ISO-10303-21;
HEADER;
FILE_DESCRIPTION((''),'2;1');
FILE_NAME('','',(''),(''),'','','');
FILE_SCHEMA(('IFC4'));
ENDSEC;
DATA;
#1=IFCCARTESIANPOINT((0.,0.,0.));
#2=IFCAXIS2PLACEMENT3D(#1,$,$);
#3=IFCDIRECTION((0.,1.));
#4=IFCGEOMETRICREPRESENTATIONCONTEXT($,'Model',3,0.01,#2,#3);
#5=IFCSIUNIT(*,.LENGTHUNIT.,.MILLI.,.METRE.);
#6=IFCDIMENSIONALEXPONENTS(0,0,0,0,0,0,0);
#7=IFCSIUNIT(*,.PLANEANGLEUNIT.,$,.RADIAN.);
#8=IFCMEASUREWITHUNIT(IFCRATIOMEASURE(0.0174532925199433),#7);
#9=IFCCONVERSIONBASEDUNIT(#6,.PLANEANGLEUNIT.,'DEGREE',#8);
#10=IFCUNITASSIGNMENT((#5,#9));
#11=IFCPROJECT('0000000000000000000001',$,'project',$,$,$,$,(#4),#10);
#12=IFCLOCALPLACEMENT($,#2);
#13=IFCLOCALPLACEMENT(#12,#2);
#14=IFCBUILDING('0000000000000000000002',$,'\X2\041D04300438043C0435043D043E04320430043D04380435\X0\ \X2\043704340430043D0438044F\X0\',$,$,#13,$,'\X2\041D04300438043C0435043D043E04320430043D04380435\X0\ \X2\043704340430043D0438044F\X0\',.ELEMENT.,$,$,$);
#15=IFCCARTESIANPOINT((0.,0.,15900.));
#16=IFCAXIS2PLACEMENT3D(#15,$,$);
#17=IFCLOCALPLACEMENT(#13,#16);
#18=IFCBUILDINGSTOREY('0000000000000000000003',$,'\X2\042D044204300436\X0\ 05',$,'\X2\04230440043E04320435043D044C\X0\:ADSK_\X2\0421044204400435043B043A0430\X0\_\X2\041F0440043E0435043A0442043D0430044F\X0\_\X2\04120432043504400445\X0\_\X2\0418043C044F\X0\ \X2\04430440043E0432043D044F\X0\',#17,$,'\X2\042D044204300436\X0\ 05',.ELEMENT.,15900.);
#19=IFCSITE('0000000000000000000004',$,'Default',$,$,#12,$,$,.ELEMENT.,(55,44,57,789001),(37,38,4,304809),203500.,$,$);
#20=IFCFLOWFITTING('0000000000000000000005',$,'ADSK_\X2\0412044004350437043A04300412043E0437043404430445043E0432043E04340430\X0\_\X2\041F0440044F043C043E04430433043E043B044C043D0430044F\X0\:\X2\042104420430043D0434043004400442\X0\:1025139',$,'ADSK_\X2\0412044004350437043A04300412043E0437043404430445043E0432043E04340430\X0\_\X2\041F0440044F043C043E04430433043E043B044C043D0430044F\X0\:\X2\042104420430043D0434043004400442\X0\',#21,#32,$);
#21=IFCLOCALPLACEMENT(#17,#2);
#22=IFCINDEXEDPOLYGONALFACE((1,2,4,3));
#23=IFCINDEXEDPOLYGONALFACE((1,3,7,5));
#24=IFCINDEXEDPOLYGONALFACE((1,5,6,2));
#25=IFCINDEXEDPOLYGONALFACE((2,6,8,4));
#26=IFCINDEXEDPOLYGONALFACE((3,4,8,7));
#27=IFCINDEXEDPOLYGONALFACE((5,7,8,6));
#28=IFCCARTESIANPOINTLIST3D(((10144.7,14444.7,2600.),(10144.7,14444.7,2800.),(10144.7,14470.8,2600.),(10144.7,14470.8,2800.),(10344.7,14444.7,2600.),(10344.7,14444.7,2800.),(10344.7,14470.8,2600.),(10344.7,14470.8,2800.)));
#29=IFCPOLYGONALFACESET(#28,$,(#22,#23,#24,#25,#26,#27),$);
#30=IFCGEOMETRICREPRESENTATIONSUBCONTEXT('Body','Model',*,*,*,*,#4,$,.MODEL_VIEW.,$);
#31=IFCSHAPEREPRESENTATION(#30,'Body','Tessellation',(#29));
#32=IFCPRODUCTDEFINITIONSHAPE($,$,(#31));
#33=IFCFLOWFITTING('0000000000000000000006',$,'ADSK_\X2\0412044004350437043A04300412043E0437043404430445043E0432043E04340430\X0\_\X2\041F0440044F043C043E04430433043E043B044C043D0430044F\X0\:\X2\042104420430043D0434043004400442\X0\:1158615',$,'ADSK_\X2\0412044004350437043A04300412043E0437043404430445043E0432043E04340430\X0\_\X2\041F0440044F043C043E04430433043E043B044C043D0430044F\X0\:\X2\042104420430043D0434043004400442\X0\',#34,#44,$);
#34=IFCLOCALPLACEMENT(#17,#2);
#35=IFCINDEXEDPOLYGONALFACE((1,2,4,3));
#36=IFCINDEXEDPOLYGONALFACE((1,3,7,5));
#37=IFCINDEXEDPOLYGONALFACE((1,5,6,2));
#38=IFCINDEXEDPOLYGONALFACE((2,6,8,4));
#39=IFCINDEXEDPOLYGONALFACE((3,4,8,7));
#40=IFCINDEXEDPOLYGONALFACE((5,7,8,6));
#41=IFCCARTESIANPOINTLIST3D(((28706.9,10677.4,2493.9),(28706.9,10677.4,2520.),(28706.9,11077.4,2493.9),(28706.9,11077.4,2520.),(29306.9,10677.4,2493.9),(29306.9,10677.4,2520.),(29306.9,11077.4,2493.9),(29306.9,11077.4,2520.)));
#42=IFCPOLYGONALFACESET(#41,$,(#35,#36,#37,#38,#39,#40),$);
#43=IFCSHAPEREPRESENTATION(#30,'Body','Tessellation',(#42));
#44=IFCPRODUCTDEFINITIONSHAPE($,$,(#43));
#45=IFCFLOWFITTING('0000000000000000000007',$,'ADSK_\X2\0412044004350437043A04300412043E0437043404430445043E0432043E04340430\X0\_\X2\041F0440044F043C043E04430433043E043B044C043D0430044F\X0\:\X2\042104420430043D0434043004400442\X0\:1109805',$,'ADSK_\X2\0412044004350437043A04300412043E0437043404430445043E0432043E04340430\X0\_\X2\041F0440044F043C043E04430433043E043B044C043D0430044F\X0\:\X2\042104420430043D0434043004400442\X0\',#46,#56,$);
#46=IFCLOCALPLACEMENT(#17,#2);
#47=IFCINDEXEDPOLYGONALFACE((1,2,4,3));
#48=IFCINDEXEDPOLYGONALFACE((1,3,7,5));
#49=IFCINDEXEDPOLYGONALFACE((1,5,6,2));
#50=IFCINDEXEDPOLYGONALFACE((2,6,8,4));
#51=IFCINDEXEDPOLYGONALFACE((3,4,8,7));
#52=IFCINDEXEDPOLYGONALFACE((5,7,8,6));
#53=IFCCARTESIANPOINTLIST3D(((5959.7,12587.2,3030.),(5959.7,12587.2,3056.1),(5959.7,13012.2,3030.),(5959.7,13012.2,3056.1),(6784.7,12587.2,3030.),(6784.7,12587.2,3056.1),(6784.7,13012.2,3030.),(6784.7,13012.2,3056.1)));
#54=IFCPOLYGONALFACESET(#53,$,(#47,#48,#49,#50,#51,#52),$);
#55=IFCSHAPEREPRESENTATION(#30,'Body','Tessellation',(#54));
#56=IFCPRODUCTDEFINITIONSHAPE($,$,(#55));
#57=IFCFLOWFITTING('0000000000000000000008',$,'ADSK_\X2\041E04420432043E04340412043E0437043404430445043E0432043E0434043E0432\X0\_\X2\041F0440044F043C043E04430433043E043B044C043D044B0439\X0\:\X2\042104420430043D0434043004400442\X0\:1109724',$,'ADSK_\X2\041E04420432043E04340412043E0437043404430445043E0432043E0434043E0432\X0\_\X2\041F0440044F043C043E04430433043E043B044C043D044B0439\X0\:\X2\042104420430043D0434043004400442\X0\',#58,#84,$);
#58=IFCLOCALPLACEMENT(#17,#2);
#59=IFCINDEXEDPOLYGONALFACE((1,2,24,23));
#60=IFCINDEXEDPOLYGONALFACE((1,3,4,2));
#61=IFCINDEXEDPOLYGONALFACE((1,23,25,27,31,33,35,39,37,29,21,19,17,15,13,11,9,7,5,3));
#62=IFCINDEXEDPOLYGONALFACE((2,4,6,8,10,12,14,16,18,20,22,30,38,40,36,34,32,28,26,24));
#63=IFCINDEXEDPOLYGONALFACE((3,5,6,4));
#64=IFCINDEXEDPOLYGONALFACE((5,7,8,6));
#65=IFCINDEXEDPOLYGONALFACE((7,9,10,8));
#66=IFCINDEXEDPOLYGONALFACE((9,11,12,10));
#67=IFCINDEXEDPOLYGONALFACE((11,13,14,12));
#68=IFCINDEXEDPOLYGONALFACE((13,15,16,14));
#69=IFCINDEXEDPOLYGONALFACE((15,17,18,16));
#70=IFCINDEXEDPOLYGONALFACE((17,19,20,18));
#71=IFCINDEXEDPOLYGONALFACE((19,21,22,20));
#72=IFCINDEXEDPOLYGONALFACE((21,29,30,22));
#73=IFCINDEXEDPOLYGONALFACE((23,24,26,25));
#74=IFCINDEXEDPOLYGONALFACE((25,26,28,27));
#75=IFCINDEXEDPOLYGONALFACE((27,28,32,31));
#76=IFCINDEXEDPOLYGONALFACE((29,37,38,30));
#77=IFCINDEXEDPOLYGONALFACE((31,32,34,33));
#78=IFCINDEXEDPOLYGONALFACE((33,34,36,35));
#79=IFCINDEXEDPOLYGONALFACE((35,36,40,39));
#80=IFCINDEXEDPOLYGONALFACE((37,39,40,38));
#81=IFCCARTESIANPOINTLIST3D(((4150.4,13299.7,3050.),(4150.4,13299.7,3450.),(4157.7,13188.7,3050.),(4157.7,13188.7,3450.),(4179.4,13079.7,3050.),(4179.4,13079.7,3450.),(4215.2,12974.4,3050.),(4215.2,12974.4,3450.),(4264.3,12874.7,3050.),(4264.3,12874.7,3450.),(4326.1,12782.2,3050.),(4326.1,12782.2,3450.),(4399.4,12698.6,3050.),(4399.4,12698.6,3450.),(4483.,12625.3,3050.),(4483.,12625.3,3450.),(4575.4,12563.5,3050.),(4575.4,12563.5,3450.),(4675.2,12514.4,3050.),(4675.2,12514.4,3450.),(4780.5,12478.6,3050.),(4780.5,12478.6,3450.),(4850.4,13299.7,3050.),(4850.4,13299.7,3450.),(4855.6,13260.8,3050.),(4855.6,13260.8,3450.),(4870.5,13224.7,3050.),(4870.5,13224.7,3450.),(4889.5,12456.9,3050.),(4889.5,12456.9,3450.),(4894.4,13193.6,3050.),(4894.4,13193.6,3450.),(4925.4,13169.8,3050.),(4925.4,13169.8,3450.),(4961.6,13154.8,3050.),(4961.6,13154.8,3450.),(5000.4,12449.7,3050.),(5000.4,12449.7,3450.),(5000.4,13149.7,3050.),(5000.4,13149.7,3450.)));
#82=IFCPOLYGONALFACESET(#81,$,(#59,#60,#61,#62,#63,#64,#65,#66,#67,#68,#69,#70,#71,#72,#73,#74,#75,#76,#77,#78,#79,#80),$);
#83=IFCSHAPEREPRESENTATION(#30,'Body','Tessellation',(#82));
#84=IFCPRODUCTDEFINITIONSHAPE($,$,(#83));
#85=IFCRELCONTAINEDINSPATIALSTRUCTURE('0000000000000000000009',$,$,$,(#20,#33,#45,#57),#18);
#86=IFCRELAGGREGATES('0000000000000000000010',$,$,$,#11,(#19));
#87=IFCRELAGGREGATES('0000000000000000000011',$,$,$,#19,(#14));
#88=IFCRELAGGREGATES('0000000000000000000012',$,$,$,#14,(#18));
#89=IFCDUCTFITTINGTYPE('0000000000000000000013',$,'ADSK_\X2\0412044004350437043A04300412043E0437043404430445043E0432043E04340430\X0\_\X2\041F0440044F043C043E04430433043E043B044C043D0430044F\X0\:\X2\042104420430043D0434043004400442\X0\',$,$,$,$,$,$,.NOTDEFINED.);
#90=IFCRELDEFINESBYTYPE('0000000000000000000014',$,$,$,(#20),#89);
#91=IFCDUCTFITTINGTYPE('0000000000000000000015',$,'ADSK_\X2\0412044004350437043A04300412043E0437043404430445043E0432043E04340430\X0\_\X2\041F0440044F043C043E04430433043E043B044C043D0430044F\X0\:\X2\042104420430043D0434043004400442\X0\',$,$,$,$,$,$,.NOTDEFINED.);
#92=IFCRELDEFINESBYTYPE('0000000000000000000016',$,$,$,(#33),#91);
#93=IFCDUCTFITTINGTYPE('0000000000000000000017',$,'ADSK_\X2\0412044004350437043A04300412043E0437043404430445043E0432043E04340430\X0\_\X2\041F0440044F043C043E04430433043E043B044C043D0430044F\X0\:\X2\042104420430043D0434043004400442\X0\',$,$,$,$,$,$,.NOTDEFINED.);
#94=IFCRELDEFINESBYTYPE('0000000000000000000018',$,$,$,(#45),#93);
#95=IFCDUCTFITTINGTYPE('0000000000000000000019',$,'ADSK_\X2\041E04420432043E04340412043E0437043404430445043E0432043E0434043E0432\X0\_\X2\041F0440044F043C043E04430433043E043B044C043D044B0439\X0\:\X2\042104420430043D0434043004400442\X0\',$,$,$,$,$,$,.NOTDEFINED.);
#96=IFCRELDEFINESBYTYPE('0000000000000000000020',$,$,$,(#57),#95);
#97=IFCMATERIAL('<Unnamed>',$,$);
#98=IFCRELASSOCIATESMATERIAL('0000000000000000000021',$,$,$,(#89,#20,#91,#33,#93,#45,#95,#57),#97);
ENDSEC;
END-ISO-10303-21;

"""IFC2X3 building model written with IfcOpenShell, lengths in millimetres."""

from ifc_helpers import new_model, entity, si_unit, converted_unit, direction, frame, frame_2d, origin, origin_2d_with_axis, place, context, subcontext, project, spatial, polyline, circle_curve, parameter, trimmed, segment, composite_curve, rectangle, outline, extrude, source, transform, mapped, material, type_object, type_shapes, element, save


model = new_model("IFC2X3")

# Units and contexts
model_context = context("Model", 3, precision=0.01, world=origin(), true_north=direction((0.0, 1.0)))
body_context = subcontext(model_context, "Body", "Model", "MODEL_VIEW")
ifc_project = project(units=[si_unit("LENGTHUNIT", "METRE", prefix="MILLI"), converted_unit("PLANEANGLEUNIT", "DEGREE", entity("IfcRatioMeasure", 0.0174532925199433), si_unit("PLANEANGLEUNIT", "RADIAN"), dimensions=[0, 0, 0, 0, 0, 0, 0])], contexts=[model_context])

# Site, building, storey
site_placement = place(None, origin())
site = spatial("IfcSite", under=ifc_project, at=site_placement, Name="Default", CompositionType="ELEMENT", RefLatitude=(55, 44, 57, 789001), RefLongitude=(37, 38, 4, 304809), RefElevation=203500.0)
building_placement = place(site_placement, origin())
building = spatial("IfcBuilding", under=site, at=building_placement, Name="Наименование здания", LongName="Наименование здания", CompositionType="ELEMENT")
storey_placement = place(building_placement, frame((0.0, 0.0, 15900.0)))
storey = spatial("IfcBuildingStorey", under=building, at=storey_placement, Name="Этаж 05", ObjectType="Уровень:ADSK_Стрелка_Проектная_Вверх_Имя уровня", LongName="Этаж 05", CompositionType="ELEMENT", Elevation=15900.0)

# Shared definitions
ifc_material_1 = material(Name="<Unnamed>")

# Flow fittings
duct_fitting_type_1 = type_object("IfcDuctFittingType", Name="ADSK_ВрезкаВоздуховода_Прямоугольная:Стандарт", PredefinedType="NOTDEFINED", material=ifc_material_1)
shared_shape_1 = source(origin(), body_context, "Body", "SweptSolid", [
    extrude(rectangle(XDim=200.0, YDim=26.1, at=origin_2d_with_axis()), frame((7.0, 0.0, -100.0), z_axis=(0.0, 0.0, 1.0), x_axis=(0.0, -1.0, 0.0)), (0.0, 0.0, 1.0), 200.0),
])
type_shapes(duct_fitting_type_1, [shared_shape_1])
flow_fitting_1_placement = place(storey_placement, frame((10244.7, 14450.8, 2700.0), z_axis=(1.0, 0.0, 0.0), x_axis=(0.0, 1.0, 0.0)))
element("IfcFlowFitting", 1, at=flow_fitting_1_placement, inside=storey, type_object=duct_fitting_type_1, material=ifc_material_1, Name="ADSK_ВрезкаВоздуховода_Прямоугольная:Стандарт:1025139", ObjectType="ADSK_ВрезкаВоздуховода_Прямоугольная:Стандарт", context=body_context, shape_type="MappedRepresentation", body=[
    mapped(shared_shape_1, transform((0.0, 0.0, 0.0), scale=1.0)),
])
duct_fitting_type_2 = type_object("IfcDuctFittingType", Name="ADSK_ВрезкаВоздуховода_Прямоугольная:Стандарт", PredefinedType="NOTDEFINED", material=ifc_material_1)
shared_shape_2 = source(origin(), body_context, "Body", "SweptSolid", [
    extrude(rectangle(XDim=26.1, YDim=400.0, at=origin_2d_with_axis()), frame((7.0, 0.0, -300.0)), (0.0, 0.0, 1.0), 600.0),
])
type_shapes(duct_fitting_type_2, [shared_shape_2])
flow_fitting_2_placement = place(storey_placement, frame((29006.9, 10877.4, 2500.0), z_axis=(1.0, 0.0, 0.0), x_axis=(0.0, 0.0, 1.0)))
element("IfcFlowFitting", 2, at=flow_fitting_2_placement, inside=storey, type_object=duct_fitting_type_2, material=ifc_material_1, Name="ADSK_ВрезкаВоздуховода_Прямоугольная:Стандарт:1158615", ObjectType="ADSK_ВрезкаВоздуховода_Прямоугольная:Стандарт", context=body_context, shape_type="MappedRepresentation", body=[
    mapped(shared_shape_2, transform((0.0, 0.0, 0.0), scale=1.0)),
])
duct_fitting_type_3 = type_object("IfcDuctFittingType", Name="ADSK_ВрезкаВоздуховода_Прямоугольная:Стандарт", PredefinedType="NOTDEFINED", material=ifc_material_1)
shared_shape_3 = source(origin(), body_context, "Body", "SweptSolid", [
    extrude(rectangle(XDim=825.0, YDim=26.1, at=origin_2d_with_axis()), frame((7.0, 0.0, -212.5), z_axis=(0.0, 0.0, 1.0), x_axis=(0.0, -1.0, 0.0)), (0.0, 0.0, 1.0), 425.0),
])
type_shapes(duct_fitting_type_3, [shared_shape_3])
flow_fitting_3_placement = place(storey_placement, frame((6372.2, 12799.7, 3050.0), z_axis=(0.0, -1.0, 0.0), x_axis=(0.0, 0.0, -1.0)))
element("IfcFlowFitting", 3, at=flow_fitting_3_placement, inside=storey, type_object=duct_fitting_type_3, material=ifc_material_1, Name="ADSK_ВрезкаВоздуховода_Прямоугольная:Стандарт:1109805", ObjectType="ADSK_ВрезкаВоздуховода_Прямоугольная:Стандарт", context=body_context, shape_type="MappedRepresentation", body=[
    mapped(shared_shape_3, transform((0.0, 0.0, 0.0), scale=1.0)),
])
duct_fitting_type_4 = type_object("IfcDuctFittingType", Name="ADSK_ОтводВоздуховодов_Прямоугольный:Стандарт", PredefinedType="NOTDEFINED", material=ifc_material_1)
shared_shape_4 = source(origin(), body_context, "Body", "SweptSolid", [
    extrude(outline(composite_curve([segment(polyline([(-600.0, -250.0), (100.0, -250.0)]), True, "CONTINUOUS"), segment(trimmed(circle_curve(frame_2d((250.0, -250.0), x_axis=(0.0, 1.0)), 150.0), [parameter(0.0)], [parameter(90.0)], True, "PARAMETER"), False, "CONTINUOUS"), segment(polyline([(250.0, -100.0), (250.0, 600.0)]), True, "CONTINUOUS"), segment(trimmed(circle_curve(frame_2d((250.0, -250.0), x_axis=(0.0, 1.0)), 850.0), [parameter(0.0)], [parameter(90.0)], True, "PARAMETER"), True, "CONTINUOUS")], self_intersect=False)), frame((-250.0, 250.0, -200.0), z_axis=(0.0, 0.0, 1.0), x_axis=(-1.0, 0.0, 0.0)), (0.0, 0.0, 1.0), 400.0),
])
type_shapes(duct_fitting_type_4, [shared_shape_4])
flow_fitting_4_placement = place(storey_placement, frame((4500.4, 12799.7, 3250.0), z_axis=(0.0, 0.0, 1.0), x_axis=(0.0, -1.0, 0.0)))
element("IfcFlowFitting", 4, at=flow_fitting_4_placement, inside=storey, type_object=duct_fitting_type_4, material=ifc_material_1, Name="ADSK_ОтводВоздуховодов_Прямоугольный:Стандарт:1109724", ObjectType="ADSK_ОтводВоздуховодов_Прямоугольный:Стандарт", context=body_context, shape_type="MappedRepresentation", body=[
    mapped(shared_shape_4, transform((0.0, 0.0, 0.0), scale=1.0)),
])

save(model, "model.ifc")
